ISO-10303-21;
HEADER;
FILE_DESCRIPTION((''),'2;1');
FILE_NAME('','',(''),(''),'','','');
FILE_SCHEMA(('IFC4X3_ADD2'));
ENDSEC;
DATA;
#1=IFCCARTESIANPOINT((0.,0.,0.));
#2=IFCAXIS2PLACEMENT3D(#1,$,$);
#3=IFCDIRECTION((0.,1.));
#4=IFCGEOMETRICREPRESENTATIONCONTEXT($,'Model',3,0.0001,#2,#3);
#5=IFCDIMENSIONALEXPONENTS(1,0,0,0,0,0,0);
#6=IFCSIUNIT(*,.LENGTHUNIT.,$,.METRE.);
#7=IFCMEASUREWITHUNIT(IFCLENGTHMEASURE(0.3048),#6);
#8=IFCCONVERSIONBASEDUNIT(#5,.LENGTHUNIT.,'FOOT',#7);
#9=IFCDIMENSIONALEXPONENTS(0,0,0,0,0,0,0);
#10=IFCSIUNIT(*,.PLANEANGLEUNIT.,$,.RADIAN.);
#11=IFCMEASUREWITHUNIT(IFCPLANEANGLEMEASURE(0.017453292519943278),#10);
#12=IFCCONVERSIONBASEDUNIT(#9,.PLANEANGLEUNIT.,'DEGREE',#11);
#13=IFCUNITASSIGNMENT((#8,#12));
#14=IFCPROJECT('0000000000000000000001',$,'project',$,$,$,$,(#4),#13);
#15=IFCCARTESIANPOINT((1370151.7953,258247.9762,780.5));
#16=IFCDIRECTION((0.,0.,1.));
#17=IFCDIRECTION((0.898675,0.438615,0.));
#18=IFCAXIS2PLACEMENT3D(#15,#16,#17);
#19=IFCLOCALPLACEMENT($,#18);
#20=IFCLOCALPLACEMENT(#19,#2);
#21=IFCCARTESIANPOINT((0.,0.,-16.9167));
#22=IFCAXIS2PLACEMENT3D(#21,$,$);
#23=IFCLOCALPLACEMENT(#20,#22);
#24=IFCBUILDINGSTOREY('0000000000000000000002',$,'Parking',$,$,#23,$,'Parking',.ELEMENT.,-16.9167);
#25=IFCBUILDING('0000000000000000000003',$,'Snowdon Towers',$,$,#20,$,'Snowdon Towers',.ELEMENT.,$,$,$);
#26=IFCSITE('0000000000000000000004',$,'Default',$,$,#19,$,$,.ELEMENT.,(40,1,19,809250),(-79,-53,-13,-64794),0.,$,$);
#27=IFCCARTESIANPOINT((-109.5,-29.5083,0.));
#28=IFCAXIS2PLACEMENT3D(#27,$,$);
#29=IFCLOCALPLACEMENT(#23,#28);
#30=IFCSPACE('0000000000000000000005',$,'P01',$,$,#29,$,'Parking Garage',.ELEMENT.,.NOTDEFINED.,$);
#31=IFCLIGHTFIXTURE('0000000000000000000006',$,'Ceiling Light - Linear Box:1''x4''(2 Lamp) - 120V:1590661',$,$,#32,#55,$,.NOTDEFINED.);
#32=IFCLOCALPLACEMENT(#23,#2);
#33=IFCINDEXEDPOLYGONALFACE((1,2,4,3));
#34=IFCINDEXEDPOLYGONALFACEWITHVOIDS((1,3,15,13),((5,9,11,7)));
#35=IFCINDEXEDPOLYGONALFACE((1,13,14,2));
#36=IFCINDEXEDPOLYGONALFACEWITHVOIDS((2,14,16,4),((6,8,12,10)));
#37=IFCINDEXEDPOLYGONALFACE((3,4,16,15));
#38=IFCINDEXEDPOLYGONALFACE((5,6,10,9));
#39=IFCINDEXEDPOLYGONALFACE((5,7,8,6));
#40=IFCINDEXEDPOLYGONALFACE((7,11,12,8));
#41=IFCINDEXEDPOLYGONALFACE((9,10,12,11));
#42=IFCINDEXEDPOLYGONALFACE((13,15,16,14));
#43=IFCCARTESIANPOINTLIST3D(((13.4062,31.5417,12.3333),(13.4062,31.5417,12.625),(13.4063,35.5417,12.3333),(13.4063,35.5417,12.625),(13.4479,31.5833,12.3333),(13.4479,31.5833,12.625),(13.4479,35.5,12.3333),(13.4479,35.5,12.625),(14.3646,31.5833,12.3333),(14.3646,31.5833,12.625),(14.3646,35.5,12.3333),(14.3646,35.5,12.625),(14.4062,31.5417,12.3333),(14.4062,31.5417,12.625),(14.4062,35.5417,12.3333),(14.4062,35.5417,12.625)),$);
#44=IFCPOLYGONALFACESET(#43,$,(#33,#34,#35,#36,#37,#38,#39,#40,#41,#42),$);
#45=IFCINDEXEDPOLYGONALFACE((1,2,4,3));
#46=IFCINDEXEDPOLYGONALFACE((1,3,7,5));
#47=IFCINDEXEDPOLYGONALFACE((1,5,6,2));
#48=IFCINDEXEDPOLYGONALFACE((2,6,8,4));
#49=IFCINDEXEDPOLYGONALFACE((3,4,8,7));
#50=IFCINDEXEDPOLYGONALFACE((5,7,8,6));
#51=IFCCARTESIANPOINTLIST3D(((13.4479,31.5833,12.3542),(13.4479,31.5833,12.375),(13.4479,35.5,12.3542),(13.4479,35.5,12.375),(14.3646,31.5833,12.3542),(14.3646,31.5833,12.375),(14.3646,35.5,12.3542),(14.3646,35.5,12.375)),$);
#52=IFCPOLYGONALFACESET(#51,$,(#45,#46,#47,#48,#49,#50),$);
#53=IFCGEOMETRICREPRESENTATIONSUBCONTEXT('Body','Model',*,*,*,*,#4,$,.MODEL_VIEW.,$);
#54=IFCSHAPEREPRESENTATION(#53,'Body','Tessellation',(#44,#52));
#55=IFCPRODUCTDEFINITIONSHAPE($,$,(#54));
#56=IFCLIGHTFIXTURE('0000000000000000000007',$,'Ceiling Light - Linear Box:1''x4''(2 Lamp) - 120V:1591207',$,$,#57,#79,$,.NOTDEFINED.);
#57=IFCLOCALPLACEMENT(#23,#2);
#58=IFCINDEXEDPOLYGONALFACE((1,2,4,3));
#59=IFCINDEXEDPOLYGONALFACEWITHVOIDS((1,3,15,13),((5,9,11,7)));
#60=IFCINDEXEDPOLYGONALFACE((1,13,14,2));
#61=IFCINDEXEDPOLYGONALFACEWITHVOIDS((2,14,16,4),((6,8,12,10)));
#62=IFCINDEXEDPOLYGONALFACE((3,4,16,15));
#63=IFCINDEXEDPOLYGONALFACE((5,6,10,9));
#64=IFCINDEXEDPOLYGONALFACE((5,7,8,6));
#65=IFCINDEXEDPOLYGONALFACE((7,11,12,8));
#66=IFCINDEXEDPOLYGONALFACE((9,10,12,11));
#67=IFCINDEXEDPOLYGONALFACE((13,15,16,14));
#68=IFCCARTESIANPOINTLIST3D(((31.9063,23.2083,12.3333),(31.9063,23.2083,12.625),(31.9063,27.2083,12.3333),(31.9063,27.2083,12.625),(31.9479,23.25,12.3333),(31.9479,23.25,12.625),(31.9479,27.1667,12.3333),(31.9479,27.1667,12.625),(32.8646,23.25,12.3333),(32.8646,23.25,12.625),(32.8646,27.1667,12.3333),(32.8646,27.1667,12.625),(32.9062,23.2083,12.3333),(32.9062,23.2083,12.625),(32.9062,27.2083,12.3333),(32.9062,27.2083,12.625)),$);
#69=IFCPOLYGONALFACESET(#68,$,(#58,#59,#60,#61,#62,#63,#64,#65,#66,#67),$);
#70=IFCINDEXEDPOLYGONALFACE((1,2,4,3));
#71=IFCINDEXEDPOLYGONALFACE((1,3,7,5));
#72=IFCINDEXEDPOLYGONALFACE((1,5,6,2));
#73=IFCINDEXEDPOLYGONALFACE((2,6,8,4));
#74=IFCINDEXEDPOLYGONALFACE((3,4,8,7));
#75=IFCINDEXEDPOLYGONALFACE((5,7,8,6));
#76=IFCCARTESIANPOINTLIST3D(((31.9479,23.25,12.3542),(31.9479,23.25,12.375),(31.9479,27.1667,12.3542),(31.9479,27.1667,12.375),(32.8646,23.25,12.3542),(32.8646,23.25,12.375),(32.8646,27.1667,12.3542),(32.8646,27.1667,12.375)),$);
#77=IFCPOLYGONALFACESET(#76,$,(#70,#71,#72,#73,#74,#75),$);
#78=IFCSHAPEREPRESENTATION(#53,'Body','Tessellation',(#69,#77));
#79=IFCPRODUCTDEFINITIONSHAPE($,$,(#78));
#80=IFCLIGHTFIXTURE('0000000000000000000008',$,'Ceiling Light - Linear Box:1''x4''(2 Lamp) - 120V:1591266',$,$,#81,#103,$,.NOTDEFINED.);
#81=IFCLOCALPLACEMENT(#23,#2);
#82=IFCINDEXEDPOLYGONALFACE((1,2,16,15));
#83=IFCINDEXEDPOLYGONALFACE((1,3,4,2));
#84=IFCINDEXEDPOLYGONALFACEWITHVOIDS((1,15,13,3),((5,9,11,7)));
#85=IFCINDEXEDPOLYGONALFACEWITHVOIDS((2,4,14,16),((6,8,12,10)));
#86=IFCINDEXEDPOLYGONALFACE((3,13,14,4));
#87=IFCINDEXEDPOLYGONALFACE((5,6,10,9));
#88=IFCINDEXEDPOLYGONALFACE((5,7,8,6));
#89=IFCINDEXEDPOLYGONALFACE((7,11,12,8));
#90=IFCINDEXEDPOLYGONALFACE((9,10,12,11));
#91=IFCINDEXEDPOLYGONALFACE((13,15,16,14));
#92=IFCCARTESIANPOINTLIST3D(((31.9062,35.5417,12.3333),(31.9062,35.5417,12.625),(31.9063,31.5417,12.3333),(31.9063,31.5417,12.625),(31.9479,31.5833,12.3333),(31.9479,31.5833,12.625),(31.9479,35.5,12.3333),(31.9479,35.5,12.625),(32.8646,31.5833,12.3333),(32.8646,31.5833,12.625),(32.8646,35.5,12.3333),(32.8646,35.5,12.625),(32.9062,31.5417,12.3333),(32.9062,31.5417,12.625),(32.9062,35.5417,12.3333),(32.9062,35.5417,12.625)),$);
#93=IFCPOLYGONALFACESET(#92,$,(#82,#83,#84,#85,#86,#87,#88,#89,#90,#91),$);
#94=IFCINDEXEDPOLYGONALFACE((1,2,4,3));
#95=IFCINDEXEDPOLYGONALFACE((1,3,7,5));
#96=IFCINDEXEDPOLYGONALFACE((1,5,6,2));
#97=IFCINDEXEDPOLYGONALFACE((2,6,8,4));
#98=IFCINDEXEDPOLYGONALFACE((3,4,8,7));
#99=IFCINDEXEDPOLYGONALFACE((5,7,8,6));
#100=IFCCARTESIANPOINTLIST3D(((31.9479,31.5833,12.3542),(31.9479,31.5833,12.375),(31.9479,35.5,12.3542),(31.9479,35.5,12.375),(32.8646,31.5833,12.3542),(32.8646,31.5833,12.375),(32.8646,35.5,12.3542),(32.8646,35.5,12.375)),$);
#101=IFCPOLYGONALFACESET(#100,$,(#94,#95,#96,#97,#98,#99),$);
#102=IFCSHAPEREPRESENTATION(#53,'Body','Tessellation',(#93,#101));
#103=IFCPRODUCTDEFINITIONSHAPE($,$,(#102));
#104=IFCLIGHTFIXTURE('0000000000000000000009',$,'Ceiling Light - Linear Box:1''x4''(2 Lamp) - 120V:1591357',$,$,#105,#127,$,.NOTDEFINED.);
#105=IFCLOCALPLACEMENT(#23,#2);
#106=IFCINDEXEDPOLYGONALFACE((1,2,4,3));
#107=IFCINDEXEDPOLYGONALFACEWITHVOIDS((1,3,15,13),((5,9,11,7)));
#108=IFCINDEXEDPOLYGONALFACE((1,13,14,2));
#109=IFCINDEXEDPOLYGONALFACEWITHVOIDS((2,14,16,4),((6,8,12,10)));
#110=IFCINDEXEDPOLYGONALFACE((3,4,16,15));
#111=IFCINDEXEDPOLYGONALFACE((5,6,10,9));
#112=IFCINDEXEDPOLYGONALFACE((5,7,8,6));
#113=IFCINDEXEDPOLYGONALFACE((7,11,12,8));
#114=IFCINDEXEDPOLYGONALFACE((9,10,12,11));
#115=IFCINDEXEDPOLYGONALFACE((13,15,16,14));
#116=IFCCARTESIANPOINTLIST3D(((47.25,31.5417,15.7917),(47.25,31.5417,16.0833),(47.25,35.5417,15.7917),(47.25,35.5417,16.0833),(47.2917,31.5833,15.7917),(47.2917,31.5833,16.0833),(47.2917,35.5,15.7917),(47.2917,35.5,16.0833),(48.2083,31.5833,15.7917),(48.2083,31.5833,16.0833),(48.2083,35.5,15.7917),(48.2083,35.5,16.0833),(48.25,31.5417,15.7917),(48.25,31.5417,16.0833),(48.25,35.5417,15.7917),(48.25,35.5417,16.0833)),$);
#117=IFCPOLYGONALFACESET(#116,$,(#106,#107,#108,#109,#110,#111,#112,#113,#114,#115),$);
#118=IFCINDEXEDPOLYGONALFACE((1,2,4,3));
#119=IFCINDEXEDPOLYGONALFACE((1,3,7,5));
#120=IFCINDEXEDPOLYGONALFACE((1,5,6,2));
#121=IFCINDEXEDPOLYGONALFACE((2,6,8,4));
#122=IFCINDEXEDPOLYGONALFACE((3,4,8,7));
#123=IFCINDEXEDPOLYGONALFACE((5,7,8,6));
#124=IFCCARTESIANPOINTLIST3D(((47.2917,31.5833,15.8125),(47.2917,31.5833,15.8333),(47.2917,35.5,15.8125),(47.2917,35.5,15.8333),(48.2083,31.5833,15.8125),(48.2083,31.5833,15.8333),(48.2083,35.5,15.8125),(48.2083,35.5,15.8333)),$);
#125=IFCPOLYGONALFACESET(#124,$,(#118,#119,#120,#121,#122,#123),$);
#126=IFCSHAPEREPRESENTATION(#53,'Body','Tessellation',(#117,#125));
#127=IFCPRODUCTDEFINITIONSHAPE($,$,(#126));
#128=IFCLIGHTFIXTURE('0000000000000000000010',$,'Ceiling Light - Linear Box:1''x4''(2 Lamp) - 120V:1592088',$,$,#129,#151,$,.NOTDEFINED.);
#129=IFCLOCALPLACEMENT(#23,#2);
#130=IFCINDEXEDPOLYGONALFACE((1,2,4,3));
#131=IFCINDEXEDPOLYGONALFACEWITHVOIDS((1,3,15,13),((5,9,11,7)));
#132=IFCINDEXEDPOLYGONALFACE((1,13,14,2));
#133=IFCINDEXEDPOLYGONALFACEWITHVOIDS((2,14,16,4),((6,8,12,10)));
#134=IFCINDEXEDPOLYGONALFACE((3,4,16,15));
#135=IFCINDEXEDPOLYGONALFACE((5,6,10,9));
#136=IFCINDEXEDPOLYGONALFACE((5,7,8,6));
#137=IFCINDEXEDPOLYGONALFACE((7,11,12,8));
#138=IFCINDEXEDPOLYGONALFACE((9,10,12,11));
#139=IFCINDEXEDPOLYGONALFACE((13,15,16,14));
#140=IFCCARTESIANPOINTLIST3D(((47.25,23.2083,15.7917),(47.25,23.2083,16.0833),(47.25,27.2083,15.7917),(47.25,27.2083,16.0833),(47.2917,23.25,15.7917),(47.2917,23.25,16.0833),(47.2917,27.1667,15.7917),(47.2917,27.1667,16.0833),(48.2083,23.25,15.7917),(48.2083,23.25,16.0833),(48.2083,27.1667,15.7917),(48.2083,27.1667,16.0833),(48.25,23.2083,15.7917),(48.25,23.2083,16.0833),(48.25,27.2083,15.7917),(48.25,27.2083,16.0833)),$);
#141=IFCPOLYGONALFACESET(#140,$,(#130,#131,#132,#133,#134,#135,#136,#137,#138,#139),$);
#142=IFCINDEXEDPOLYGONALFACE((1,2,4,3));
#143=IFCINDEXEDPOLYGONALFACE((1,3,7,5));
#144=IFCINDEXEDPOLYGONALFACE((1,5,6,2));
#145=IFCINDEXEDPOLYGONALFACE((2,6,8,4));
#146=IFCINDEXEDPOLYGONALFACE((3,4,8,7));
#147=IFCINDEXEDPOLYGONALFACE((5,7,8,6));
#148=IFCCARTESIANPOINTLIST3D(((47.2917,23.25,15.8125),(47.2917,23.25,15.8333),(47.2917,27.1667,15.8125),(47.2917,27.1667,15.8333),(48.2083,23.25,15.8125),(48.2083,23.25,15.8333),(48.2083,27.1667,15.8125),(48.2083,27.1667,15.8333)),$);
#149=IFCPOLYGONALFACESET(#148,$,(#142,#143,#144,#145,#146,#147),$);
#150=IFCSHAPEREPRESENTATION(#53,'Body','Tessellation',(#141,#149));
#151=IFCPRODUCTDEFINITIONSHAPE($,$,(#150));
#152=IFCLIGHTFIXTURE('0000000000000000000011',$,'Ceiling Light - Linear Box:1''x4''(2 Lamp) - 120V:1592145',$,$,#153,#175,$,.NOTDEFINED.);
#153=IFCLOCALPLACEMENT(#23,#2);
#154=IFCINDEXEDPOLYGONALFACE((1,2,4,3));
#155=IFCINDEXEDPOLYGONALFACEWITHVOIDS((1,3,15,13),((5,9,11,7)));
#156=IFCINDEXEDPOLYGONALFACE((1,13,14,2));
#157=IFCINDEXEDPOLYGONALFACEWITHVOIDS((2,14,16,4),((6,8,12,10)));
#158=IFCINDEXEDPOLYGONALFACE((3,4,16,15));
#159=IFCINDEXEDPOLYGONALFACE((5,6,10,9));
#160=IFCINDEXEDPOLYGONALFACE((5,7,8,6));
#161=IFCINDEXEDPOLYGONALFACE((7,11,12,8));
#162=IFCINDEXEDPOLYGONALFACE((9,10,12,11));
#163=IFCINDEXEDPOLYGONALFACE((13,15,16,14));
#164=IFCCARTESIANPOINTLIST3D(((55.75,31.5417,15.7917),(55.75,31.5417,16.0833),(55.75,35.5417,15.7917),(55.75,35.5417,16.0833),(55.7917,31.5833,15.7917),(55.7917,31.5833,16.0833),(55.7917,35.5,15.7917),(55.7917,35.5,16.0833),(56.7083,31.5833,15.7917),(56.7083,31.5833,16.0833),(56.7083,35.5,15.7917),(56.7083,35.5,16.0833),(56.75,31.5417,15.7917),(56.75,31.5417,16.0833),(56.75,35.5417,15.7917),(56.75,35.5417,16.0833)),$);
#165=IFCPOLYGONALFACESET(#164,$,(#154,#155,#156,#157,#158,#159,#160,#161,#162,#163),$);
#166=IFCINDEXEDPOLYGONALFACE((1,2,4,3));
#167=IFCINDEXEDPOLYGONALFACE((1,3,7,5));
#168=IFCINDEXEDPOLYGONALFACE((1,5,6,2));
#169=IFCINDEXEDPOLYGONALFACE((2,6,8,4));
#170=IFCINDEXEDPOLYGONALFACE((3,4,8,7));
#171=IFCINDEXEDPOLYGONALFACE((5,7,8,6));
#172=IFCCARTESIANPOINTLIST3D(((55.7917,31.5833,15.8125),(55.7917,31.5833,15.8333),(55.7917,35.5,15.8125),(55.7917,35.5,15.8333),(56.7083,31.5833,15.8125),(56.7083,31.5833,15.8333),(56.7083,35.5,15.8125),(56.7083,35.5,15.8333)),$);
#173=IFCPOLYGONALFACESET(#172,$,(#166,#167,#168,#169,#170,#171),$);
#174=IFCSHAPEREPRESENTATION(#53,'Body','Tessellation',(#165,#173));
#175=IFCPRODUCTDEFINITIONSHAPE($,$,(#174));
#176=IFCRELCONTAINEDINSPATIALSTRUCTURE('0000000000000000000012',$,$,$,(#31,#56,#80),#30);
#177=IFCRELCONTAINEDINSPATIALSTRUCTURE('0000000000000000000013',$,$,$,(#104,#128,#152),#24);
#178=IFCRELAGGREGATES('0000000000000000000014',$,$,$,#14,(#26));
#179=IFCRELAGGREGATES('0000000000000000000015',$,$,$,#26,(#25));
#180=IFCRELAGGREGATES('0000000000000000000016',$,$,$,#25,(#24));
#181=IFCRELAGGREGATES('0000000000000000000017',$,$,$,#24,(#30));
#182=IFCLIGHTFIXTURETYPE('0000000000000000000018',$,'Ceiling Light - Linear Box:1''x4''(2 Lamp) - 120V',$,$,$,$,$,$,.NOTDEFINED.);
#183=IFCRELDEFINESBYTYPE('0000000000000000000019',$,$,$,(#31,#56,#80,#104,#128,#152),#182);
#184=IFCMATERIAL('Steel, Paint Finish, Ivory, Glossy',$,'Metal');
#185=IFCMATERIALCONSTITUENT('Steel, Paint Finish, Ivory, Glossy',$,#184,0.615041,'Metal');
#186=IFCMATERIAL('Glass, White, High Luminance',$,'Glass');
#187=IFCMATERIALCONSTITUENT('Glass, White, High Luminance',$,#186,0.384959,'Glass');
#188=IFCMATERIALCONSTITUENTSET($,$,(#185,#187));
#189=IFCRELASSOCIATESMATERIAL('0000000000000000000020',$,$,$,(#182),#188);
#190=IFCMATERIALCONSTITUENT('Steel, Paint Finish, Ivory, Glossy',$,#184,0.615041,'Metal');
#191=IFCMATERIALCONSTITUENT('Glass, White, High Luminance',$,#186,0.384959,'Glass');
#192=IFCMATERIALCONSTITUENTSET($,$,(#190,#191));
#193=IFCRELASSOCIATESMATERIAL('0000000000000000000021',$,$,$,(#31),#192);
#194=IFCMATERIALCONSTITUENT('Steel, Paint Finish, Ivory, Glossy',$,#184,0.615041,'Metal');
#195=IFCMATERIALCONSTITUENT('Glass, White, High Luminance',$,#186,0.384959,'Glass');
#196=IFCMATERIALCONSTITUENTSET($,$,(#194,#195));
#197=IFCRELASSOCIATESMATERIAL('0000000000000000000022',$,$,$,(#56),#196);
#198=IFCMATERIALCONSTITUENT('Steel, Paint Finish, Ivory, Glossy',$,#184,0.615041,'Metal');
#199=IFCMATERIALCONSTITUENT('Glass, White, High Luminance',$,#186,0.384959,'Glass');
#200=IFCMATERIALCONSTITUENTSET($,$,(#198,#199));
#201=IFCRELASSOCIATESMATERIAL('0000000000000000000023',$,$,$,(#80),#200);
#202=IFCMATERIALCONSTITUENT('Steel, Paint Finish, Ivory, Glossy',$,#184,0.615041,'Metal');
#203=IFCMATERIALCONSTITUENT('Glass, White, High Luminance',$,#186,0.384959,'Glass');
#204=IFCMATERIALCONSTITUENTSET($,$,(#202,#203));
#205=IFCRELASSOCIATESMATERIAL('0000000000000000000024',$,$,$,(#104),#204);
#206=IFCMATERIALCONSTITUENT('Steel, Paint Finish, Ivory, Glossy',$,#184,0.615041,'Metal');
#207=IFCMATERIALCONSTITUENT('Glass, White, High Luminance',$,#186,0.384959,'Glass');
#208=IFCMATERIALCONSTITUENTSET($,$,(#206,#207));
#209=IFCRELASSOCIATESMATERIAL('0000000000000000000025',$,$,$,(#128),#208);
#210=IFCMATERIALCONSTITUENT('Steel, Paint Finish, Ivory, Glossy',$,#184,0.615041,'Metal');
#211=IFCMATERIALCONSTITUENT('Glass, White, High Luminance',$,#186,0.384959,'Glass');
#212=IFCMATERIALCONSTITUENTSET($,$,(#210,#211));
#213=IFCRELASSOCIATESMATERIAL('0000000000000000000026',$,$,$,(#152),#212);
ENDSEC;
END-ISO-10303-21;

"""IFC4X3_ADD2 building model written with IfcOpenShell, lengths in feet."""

from ifc_helpers import new_model, entity, si_unit, converted_unit, direction, frame, origin, origin_2d_with_axis, place, context, subcontext, project, spatial, polyline, rectangle, outline, extrude, source, transform, mapped, material, constituent, constituent_set, type_object, type_shapes, element, save


model = new_model("IFC4X3_ADD2")

# Units and contexts
model_context = context("Model", 3, precision=0.0001, world=origin(), true_north=direction((0.0, 1.0)))
body_context = subcontext(model_context, "Body", "Model", "MODEL_VIEW")
ifc_project = project(units=[converted_unit("LENGTHUNIT", "FOOT", entity("IfcLengthMeasure", 0.3048), si_unit("LENGTHUNIT", "METRE"), dimensions=[1, 0, 0, 0, 0, 0, 0]), converted_unit("PLANEANGLEUNIT", "DEGREE", entity("IfcPlaneAngleMeasure", 0.017453292519943278), si_unit("PLANEANGLEUNIT", "RADIAN"), dimensions=[0, 0, 0, 0, 0, 0, 0])], contexts=[model_context])

# Site, building, storey
site_placement = place(None, frame((1370151.7953, 258247.9762, 780.5), z_axis=(0.0, 0.0, 1.0), x_axis=(0.898675, 0.438615, 0.0)))
site = spatial("IfcSite", under=ifc_project, at=site_placement, Name="Default", CompositionType="ELEMENT", RefLatitude=(40, 1, 19, 809250), RefLongitude=(-79, -53, -13, -64794), RefElevation=0.0)
building_placement = place(site_placement, origin())
building = spatial("IfcBuilding", under=site, at=building_placement, Name="Snowdon Towers", LongName="Snowdon Towers", CompositionType="ELEMENT")
storey_placement = place(building_placement, frame((0.0, 0.0, -16.9167)))
storey = spatial("IfcBuildingStorey", under=building, at=storey_placement, Name="Parking", LongName="Parking", CompositionType="ELEMENT", Elevation=-16.9167)

# Shared definitions
space_1_placement = place(storey_placement, frame((-109.5, -29.5083, 0.0)))
space_1 = spatial("IfcSpace", under=storey, at=space_1_placement, Name="P01", LongName="Parking Garage", CompositionType="ELEMENT", PredefinedType="NOTDEFINED")

# Light fixtures
ifc_material_1 = material(Name="Steel, Paint Finish, Ivory, Glossy", Category="Metal")
ifc_constituent_1 = constituent(ifc_material_1, Name="Steel, Paint Finish, Ivory, Glossy", Category="Metal", fraction=0.615041)
ifc_material_2 = material(Name="Glass, White, High Luminance", Category="Glass")
ifc_constituent_2 = constituent(ifc_material_2, Name="Glass, White, High Luminance", Category="Glass", fraction=0.384959)
ifc_constituent_set_1 = constituent_set(constituents=[ifc_constituent_1, ifc_constituent_2])
ifc_constituent_3 = constituent(ifc_material_1, Name="Steel, Paint Finish, Ivory, Glossy", Category="Metal", fraction=0.615041)
ifc_constituent_4 = constituent(ifc_material_2, Name="Glass, White, High Luminance", Category="Glass", fraction=0.384959)
ifc_constituent_set_2 = constituent_set(constituents=[ifc_constituent_3, ifc_constituent_4])
light_fixture_type = type_object("IfcLightFixtureType", Name="Ceiling Light - Linear Box:1'x4'(2 Lamp) - 120V", PredefinedType="NOTDEFINED", material=ifc_constituent_set_2)
shared_shape_1 = source(origin(), body_context, "Body", "SweptSolid", [
    extrude(outline(polyline([(-2.0, -0.5), (2.0, -0.5), (2.0, 0.5), (-2.0, 0.5), (-2.0, -0.5)]), holes=[polyline([(-1.9583, -0.4583), (-1.9583, 0.4583), (1.9583, 0.4583), (1.9583, -0.4583), (-1.9583, -0.4583)])]), frame((0.0, -0.5, 0.0), z_axis=(0.0, 0.0, 1.0), x_axis=(-1.0, 0.0, 0.0)), (0.0, 0.0, 1.0), 0.2917),
    extrude(rectangle(XDim=3.9167, YDim=0.9167, at=origin_2d_with_axis()), frame((0.0, -0.5, 0.25), z_axis=(0.0, 0.0, 1.0), x_axis=(-1.0, 0.0, 0.0)), (0.0, 0.0, 1.0), 0.0208),
])
type_shapes(light_fixture_type, [shared_shape_1])
light_fixture_1_placement = place(space_1_placement, frame((122.9063, 63.05, 12.625), z_axis=(0.0, 0.0, -1.0), x_axis=(0.0, -1.0, 0.0)))
element("IfcLightFixture", 1, at=light_fixture_1_placement, inside=space_1, type_object=light_fixture_type, material=ifc_constituent_set_1, Name="Ceiling Light - Linear Box:1'x4'(2 Lamp) - 120V:1590661", PredefinedType="NOTDEFINED", context=body_context, shape_type="MappedRepresentation", body=[
    mapped(shared_shape_1, transform((0.0, 0.0, 0.0), scale=1.0)),
])
ifc_constituent_5 = constituent(ifc_material_1, Name="Steel, Paint Finish, Ivory, Glossy", Category="Metal", fraction=0.615041)
ifc_constituent_6 = constituent(ifc_material_2, Name="Glass, White, High Luminance", Category="Glass", fraction=0.384959)
ifc_constituent_set_3 = constituent_set(constituents=[ifc_constituent_5, ifc_constituent_6])
light_fixture_2_placement = place(space_1_placement, frame((141.4063, 54.7166, 12.625), z_axis=(0.0, 0.0, -1.0), x_axis=(0.0, -1.0, 0.0)))
element("IfcLightFixture", 2, at=light_fixture_2_placement, inside=space_1, type_object=light_fixture_type, material=ifc_constituent_set_3, Name="Ceiling Light - Linear Box:1'x4'(2 Lamp) - 120V:1591207", PredefinedType="NOTDEFINED", context=body_context, shape_type="MappedRepresentation", body=[
    mapped(shared_shape_1, transform((0.0, 0.0, 0.0), scale=1.0)),
])
ifc_constituent_7 = constituent(ifc_material_1, Name="Steel, Paint Finish, Ivory, Glossy", Category="Metal", fraction=0.615041)
ifc_constituent_8 = constituent(ifc_material_2, Name="Glass, White, High Luminance", Category="Glass", fraction=0.384959)
ifc_constituent_set_4 = constituent_set(constituents=[ifc_constituent_7, ifc_constituent_8])
light_fixture_3_placement = place(space_1_placement, frame((141.4063, 63.05, 12.625), z_axis=(0.0, 0.0, -1.0), x_axis=(0.0, -1.0, 0.0)))
element("IfcLightFixture", 3, at=light_fixture_3_placement, inside=space_1, type_object=light_fixture_type, material=ifc_constituent_set_4, Name="Ceiling Light - Linear Box:1'x4'(2 Lamp) - 120V:1591266", PredefinedType="NOTDEFINED", context=body_context, shape_type="MappedRepresentation", body=[
    mapped(shared_shape_1, transform((0.0, 0.0, 0.0), scale=1.0)),
])
ifc_constituent_9 = constituent(ifc_material_1, Name="Steel, Paint Finish, Ivory, Glossy", Category="Metal", fraction=0.615041)
ifc_constituent_10 = constituent(ifc_material_2, Name="Glass, White, High Luminance", Category="Glass", fraction=0.384959)
ifc_constituent_set_5 = constituent_set(constituents=[ifc_constituent_9, ifc_constituent_10])
light_fixture_4_placement = place(storey_placement, frame((47.25, 33.5417, 16.0833), z_axis=(0.0, 0.0, -1.0), x_axis=(0.0, -1.0, 0.0)))
element("IfcLightFixture", 4, at=light_fixture_4_placement, inside=storey, type_object=light_fixture_type, material=ifc_constituent_set_5, Name="Ceiling Light - Linear Box:1'x4'(2 Lamp) - 120V:1591357", PredefinedType="NOTDEFINED", context=body_context, shape_type="MappedRepresentation", body=[
    mapped(shared_shape_1, transform((0.0, 0.0, 0.0), scale=1.0)),
])
ifc_constituent_11 = constituent(ifc_material_1, Name="Steel, Paint Finish, Ivory, Glossy", Category="Metal", fraction=0.615041)
ifc_constituent_12 = constituent(ifc_material_2, Name="Glass, White, High Luminance", Category="Glass", fraction=0.384959)
ifc_constituent_set_6 = constituent_set(constituents=[ifc_constituent_11, ifc_constituent_12])
light_fixture_5_placement = place(storey_placement, frame((47.25, 25.2083, 16.0833), z_axis=(0.0, 0.0, -1.0), x_axis=(0.0, -1.0, 0.0)))
element("IfcLightFixture", 5, at=light_fixture_5_placement, inside=storey, type_object=light_fixture_type, material=ifc_constituent_set_6, Name="Ceiling Light - Linear Box:1'x4'(2 Lamp) - 120V:1592088", PredefinedType="NOTDEFINED", context=body_context, shape_type="MappedRepresentation", body=[
    mapped(shared_shape_1, transform((0.0, 0.0, 0.0), scale=1.0)),
])
ifc_constituent_13 = constituent(ifc_material_1, Name="Steel, Paint Finish, Ivory, Glossy", Category="Metal", fraction=0.615041)
ifc_constituent_14 = constituent(ifc_material_2, Name="Glass, White, High Luminance", Category="Glass", fraction=0.384959)
ifc_constituent_set_7 = constituent_set(constituents=[ifc_constituent_13, ifc_constituent_14])
light_fixture_6_placement = place(storey_placement, frame((55.75, 33.5417, 16.0833), z_axis=(0.0, 0.0, -1.0), x_axis=(0.0, -1.0, 0.0)))
element("IfcLightFixture", 6, at=light_fixture_6_placement, inside=storey, type_object=light_fixture_type, material=ifc_constituent_set_7, Name="Ceiling Light - Linear Box:1'x4'(2 Lamp) - 120V:1592145", PredefinedType="NOTDEFINED", context=body_context, shape_type="MappedRepresentation", body=[
    mapped(shared_shape_1, transform((0.0, 0.0, 0.0), scale=1.0)),
])

save(model, "model.ifc")
